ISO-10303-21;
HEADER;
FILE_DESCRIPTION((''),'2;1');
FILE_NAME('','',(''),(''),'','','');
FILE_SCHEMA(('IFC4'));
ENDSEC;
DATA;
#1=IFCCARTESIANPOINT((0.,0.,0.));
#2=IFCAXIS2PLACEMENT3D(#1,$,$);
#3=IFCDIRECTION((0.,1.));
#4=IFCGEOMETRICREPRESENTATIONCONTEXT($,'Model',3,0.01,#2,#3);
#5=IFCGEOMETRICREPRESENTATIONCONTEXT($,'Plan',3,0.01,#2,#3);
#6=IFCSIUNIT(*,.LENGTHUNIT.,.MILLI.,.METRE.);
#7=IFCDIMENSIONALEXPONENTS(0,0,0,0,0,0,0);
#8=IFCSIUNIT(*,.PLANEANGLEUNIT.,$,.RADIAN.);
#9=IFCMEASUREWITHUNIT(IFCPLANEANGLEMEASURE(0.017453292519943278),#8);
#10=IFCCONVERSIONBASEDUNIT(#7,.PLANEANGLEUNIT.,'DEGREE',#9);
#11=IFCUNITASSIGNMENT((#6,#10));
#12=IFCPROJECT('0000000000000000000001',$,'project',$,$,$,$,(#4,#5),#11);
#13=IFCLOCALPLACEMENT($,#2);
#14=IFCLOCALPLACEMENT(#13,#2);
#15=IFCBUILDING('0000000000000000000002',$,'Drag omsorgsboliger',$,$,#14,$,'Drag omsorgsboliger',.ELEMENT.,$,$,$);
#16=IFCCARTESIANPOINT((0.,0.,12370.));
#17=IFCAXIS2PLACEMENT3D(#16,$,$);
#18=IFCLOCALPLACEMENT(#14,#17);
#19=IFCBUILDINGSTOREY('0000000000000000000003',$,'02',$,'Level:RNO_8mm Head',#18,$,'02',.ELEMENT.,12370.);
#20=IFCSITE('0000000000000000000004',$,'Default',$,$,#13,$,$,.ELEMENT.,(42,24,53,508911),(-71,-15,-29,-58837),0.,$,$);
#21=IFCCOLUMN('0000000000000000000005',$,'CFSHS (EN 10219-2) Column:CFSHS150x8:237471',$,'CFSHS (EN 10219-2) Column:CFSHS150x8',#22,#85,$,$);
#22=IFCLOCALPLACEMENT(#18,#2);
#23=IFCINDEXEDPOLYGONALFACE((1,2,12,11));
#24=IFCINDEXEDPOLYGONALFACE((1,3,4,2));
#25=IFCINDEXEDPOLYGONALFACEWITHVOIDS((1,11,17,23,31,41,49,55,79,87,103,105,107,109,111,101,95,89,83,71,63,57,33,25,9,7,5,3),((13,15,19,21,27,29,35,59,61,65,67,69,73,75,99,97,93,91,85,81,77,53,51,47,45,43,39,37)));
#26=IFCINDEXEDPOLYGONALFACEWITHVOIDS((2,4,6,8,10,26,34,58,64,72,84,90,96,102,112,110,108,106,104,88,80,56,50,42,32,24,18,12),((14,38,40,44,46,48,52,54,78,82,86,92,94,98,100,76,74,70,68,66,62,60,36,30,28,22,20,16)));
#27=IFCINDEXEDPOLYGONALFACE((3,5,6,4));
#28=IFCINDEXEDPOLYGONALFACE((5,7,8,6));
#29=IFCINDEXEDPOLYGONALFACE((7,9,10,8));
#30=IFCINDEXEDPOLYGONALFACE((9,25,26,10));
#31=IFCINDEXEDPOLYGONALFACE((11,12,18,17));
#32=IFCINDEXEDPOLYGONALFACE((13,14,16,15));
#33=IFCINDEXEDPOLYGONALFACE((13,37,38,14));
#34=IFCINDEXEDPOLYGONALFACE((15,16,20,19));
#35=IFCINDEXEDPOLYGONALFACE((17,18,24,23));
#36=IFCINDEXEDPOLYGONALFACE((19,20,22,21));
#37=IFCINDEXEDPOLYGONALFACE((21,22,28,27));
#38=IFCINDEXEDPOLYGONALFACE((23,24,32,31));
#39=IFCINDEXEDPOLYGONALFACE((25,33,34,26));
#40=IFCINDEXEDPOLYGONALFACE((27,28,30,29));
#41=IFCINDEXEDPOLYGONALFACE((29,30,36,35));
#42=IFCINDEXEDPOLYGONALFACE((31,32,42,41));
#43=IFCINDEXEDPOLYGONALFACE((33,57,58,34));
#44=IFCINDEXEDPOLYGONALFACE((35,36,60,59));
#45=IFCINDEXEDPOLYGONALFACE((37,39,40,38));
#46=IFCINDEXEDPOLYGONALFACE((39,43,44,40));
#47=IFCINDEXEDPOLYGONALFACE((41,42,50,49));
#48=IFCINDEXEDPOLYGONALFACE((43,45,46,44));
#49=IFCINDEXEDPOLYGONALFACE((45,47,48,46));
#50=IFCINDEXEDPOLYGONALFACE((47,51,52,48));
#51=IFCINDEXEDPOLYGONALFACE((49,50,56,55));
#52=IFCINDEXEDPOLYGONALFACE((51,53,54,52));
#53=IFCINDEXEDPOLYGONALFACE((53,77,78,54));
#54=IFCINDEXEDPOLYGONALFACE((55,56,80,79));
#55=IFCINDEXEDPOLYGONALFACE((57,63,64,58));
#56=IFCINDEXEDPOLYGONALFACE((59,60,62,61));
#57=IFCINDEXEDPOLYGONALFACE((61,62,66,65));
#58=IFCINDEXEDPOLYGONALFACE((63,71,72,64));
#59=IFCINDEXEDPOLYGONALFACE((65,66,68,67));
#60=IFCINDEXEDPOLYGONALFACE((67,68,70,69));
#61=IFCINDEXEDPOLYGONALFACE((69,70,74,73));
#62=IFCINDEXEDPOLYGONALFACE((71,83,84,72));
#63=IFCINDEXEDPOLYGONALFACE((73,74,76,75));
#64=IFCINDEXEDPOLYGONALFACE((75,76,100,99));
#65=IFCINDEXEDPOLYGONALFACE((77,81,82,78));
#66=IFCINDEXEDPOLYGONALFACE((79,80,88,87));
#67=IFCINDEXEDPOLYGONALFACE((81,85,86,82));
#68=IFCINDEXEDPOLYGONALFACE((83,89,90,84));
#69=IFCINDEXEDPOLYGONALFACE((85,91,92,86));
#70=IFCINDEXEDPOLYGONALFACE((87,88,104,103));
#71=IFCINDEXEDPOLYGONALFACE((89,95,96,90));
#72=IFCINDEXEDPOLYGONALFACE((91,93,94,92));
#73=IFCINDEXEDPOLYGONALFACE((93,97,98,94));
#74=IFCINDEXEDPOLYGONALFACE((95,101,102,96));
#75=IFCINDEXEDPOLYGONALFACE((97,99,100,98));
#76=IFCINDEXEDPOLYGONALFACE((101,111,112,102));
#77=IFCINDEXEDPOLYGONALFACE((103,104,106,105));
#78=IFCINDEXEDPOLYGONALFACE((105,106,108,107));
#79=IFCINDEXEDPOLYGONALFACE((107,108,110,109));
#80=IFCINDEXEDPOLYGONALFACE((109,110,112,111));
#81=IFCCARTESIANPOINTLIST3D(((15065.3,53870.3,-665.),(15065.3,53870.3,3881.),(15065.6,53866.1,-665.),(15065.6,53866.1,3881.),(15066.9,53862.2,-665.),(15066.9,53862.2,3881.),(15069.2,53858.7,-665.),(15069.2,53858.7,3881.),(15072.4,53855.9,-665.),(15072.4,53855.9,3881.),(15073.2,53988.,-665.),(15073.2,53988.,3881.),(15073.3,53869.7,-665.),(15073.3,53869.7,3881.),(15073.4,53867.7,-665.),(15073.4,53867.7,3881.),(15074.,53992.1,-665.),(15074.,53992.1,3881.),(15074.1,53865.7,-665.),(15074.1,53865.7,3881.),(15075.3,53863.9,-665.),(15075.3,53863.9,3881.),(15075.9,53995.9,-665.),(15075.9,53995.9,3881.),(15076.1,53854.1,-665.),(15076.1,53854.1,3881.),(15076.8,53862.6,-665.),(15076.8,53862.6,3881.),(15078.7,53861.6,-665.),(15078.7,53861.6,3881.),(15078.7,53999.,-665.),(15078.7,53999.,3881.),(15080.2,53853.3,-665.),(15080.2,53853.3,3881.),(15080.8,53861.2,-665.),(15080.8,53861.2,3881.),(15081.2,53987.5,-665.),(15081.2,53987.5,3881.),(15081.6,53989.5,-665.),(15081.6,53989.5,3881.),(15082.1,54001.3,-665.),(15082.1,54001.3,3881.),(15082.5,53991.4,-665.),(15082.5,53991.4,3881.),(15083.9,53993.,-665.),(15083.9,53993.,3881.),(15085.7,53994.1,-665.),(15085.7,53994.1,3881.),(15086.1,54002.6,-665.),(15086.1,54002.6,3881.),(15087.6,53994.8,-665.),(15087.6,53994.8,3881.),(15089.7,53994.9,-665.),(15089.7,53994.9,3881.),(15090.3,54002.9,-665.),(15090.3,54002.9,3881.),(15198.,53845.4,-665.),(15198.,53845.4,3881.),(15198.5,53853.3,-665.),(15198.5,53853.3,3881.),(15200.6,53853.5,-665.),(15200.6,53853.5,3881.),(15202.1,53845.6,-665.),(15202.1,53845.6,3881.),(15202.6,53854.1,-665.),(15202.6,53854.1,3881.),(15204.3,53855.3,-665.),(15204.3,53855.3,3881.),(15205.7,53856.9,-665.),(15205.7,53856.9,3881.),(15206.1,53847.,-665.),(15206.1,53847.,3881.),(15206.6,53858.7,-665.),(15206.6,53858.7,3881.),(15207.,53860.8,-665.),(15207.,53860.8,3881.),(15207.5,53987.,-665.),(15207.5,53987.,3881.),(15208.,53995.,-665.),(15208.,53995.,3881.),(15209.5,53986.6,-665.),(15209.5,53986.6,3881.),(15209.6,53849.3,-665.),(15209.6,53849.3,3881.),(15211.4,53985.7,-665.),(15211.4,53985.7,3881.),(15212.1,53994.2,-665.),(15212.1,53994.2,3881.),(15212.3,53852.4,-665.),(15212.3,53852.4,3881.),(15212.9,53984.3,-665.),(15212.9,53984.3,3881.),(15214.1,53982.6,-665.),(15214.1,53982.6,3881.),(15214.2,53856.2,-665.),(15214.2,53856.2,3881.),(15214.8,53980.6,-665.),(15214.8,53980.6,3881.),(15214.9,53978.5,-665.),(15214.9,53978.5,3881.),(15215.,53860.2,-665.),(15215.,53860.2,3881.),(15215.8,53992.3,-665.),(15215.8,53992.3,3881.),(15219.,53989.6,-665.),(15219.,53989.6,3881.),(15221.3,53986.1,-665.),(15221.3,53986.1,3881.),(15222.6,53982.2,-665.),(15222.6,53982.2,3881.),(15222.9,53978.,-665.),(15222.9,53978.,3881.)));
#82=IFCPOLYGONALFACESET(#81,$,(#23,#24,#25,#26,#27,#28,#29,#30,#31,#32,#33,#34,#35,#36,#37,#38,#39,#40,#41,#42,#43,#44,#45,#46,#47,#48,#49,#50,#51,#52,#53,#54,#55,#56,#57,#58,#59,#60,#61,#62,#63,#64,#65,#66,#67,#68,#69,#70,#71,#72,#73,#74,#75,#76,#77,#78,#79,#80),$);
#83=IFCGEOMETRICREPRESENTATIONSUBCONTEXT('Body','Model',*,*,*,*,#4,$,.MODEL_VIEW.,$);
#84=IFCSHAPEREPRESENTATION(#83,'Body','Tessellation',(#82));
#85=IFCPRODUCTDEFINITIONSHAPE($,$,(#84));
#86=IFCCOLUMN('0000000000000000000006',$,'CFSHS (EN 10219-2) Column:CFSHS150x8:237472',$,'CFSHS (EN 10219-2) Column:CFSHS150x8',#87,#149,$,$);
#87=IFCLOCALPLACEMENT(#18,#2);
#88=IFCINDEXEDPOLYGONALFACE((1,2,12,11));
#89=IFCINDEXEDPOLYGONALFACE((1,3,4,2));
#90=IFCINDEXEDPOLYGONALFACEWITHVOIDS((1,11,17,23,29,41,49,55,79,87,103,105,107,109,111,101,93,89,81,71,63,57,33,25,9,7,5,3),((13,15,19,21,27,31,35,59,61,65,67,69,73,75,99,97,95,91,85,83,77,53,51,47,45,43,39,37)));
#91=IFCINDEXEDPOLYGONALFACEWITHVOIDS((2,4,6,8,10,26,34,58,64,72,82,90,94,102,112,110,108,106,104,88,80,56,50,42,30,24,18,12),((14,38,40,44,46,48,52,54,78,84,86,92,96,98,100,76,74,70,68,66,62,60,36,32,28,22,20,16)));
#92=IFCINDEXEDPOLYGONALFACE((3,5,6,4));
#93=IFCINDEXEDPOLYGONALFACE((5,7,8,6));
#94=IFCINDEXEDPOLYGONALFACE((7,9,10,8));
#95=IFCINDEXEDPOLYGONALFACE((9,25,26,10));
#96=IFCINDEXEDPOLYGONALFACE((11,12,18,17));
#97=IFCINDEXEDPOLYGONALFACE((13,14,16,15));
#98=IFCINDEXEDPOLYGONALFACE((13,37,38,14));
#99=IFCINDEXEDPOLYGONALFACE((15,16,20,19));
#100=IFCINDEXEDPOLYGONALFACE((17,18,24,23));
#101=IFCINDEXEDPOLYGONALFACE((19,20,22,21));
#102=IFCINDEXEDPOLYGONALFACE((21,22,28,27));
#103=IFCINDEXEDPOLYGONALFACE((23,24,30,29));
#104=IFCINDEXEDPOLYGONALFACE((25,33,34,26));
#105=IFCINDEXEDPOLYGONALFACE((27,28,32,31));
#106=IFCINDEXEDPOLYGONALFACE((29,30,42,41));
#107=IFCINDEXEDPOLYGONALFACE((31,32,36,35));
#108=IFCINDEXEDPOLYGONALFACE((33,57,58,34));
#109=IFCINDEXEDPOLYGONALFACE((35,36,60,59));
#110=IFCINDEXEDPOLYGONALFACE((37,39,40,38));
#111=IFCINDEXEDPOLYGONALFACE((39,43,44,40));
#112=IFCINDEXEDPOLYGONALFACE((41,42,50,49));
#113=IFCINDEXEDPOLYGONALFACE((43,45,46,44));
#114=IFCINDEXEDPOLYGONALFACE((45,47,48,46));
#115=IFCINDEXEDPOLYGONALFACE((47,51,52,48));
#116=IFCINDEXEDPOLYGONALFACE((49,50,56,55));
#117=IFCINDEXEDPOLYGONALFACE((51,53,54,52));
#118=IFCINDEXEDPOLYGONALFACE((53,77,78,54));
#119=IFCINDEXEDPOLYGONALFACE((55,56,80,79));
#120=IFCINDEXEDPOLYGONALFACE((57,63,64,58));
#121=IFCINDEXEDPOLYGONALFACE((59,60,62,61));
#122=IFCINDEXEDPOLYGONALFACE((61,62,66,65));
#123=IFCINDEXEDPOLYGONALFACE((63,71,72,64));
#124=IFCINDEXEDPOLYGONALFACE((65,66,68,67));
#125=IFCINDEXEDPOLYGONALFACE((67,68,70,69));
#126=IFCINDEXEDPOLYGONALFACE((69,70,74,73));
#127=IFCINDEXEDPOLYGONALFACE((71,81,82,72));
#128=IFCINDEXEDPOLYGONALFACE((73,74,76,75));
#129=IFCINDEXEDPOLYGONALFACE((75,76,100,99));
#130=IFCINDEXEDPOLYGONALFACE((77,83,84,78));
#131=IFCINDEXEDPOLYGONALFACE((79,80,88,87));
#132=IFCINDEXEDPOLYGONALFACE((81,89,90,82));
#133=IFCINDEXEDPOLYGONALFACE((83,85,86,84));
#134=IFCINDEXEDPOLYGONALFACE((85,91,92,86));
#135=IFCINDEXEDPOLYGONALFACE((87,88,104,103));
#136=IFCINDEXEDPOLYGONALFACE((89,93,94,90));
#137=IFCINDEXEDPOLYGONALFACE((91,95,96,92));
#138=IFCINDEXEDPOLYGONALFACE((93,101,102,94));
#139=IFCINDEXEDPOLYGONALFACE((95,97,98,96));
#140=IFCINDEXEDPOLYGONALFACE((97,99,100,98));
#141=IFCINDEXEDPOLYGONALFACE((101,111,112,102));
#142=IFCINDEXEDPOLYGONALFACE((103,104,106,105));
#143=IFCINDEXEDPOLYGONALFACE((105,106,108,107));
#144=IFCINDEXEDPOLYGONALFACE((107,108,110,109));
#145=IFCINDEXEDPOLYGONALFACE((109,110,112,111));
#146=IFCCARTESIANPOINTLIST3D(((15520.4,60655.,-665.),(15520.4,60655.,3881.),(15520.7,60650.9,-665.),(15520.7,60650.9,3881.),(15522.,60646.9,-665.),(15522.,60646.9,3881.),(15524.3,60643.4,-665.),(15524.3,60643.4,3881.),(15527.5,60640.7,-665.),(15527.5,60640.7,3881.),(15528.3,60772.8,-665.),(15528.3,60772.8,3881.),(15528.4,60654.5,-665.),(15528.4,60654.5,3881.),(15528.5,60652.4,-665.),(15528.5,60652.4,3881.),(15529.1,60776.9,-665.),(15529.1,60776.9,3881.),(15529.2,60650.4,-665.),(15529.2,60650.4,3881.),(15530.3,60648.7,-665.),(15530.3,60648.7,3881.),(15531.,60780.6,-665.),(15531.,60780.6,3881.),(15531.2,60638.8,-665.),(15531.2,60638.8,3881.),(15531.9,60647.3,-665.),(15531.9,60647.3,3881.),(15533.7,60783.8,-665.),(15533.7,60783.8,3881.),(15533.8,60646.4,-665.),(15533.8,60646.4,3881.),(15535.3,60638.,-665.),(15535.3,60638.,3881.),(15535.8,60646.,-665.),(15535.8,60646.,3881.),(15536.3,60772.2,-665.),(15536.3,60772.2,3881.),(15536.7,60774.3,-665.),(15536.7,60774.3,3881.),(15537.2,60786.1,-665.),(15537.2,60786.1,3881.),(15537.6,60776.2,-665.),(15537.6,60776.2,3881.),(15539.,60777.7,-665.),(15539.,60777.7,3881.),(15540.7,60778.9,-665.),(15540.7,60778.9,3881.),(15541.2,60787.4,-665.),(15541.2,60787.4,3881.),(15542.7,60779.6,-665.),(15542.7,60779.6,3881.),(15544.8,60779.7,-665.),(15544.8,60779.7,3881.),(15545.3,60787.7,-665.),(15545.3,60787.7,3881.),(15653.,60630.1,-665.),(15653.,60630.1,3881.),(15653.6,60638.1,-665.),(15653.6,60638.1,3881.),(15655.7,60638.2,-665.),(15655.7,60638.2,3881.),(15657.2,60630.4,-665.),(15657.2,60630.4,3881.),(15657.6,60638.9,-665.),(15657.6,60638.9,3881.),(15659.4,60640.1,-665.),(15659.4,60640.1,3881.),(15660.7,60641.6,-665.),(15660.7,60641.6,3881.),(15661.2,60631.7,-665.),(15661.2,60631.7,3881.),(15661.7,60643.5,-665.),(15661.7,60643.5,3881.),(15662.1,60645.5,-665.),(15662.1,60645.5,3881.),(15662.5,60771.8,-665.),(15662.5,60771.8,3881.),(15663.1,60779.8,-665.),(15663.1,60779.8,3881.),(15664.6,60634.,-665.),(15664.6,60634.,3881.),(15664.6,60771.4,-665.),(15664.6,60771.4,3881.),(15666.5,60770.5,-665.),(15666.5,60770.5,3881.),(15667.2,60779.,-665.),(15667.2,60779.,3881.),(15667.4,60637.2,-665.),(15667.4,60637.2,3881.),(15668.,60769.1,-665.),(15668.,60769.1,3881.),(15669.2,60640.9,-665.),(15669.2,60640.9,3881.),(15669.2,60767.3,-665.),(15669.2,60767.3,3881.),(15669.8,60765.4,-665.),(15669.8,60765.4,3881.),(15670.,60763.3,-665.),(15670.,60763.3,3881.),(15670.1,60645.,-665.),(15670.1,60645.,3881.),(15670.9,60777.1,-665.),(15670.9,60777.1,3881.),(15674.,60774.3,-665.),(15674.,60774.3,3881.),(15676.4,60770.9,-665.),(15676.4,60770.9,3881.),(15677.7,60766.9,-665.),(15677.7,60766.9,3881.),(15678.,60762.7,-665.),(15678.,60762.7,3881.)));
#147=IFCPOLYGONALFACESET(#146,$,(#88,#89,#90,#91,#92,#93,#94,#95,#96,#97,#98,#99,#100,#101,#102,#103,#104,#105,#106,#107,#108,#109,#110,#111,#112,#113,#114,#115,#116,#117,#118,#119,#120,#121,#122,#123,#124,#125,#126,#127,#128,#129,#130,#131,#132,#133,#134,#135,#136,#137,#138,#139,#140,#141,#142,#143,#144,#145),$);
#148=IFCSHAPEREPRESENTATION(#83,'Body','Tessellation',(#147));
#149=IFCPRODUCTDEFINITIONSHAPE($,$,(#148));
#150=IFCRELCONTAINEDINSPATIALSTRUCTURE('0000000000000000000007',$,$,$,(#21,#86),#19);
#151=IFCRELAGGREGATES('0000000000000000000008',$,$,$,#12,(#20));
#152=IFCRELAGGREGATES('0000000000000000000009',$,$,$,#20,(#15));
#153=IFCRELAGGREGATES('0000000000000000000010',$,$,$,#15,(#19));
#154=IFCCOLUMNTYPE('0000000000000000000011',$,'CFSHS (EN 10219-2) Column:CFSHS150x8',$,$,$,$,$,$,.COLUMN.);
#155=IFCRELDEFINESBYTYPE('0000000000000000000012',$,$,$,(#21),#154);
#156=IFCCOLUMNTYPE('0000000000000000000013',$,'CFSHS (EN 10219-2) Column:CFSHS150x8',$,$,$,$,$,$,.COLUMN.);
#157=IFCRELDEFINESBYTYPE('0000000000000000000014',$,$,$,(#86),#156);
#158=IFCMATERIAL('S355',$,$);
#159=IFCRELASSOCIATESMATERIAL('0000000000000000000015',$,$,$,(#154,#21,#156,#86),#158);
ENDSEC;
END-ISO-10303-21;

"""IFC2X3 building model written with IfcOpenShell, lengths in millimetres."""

from ifc_helpers import new_model, entity, si_unit, converted_unit, direction, frame, frame_2d, origin, place, context, subcontext, project, spatial, polyline, circle_curve, parameter, trimmed, segment, composite_curve, outline, extrude, source, transform, mapped, material, type_object, type_shapes, element, save


model = new_model("IFC2X3")

# Units and contexts
model_context = context("Model", 3, precision=0.01, world=origin(), true_north=direction((0.0, 1.0)))
plan_context = context("Plan", 3, precision=0.01, world=origin(), true_north=direction((0.0, 1.0)))
body_context = subcontext(model_context, "Body", "Model", "MODEL_VIEW")
ifc_project = project(units=[si_unit("LENGTHUNIT", "METRE", prefix="MILLI"), converted_unit("PLANEANGLEUNIT", "DEGREE", entity("IfcPlaneAngleMeasure", 0.017453292519943278), si_unit("PLANEANGLEUNIT", "RADIAN"), dimensions=[0, 0, 0, 0, 0, 0, 0])], contexts=[model_context, plan_context])

# Site, building, storey
site_placement = place(None, origin())
site = spatial("IfcSite", under=ifc_project, at=site_placement, Name="Default", CompositionType="ELEMENT", RefLatitude=(42, 24, 53, 508911), RefLongitude=(-71, -15, -29, -58837), RefElevation=0.0)
building_placement = place(site_placement, origin())
building = spatial("IfcBuilding", under=site, at=building_placement, Name="Drag omsorgsboliger", LongName="Drag omsorgsboliger", CompositionType="ELEMENT")
storey_placement = place(building_placement, frame((0.0, 0.0, 12370.0)))
storey = spatial("IfcBuildingStorey", under=building, at=storey_placement, Name="02", ObjectType="Level:RNO_8mm Head", LongName="02", CompositionType="ELEMENT", Elevation=12370.0)

# Columns
ifc_material = material(Name="S355")
column_type_1 = type_object("IfcColumnType", Name="CFSHS (EN 10219-2) Column:CFSHS150x8", PredefinedType="COLUMN", material=ifc_material)
shared_shape_1 = source(origin(), body_context, "Body", "SweptSolid", [
    extrude(outline(composite_curve([segment(polyline([(-59.0, -75.0), (59.0, -75.0)]), True, "CONTINUOUS"), segment(trimmed(circle_curve(frame_2d((59.0, -59.0), x_axis=(-1.0, 0.0)), 16.0), [parameter(90.0)], [parameter(180.0)], True, "PARAMETER"), True, "CONTINUOUS"), segment(polyline([(75.0, -59.0), (75.0, 59.0)]), True, "CONTINUOUS"), segment(trimmed(circle_curve(frame_2d((59.0, 59.0), x_axis=(-1.0, 0.0)), 16.0), [parameter(180.0)], [parameter(270.0)], True, "PARAMETER"), True, "CONTINUOUS"), segment(polyline([(59.0, 75.0), (-59.0, 75.0)]), True, "CONTINUOUS"), segment(trimmed(circle_curve(frame_2d((-59.0, 59.0), x_axis=(-1.0, 0.0)), 16.0), [parameter(270.0)], [parameter(360.0)], True, "PARAMETER"), True, "CONTINUOUS"), segment(polyline([(-75.0, 59.0), (-75.0, -59.0)]), True, "CONTINUOUS"), segment(trimmed(circle_curve(frame_2d((-59.0, -59.0), x_axis=(-1.0, 0.0)), 16.0), [parameter(360.0)], [parameter(90.0)], True, "PARAMETER"), True, "CONTINUOUS")], self_intersect=False), holes=[composite_curve([segment(trimmed(circle_curve(frame_2d((-59.0, -59.0), x_axis=(-1.0, 0.0)), 8.0), [parameter(360.0)], [parameter(90.0)], True, "PARAMETER"), False, "CONTINUOUS"), segment(polyline([(-67.0, -59.0), (-67.0, 59.0)]), True, "CONTINUOUS"), segment(trimmed(circle_curve(frame_2d((-59.0, 59.0), x_axis=(-1.0, 0.0)), 8.0), [parameter(270.0)], [parameter(360.0)], True, "PARAMETER"), False, "CONTINUOUS"), segment(polyline([(-59.0, 67.0), (59.0, 67.0)]), True, "CONTINUOUS"), segment(trimmed(circle_curve(frame_2d((59.0, 59.0), x_axis=(-1.0, 0.0)), 8.0), [parameter(180.0)], [parameter(270.0)], True, "PARAMETER"), False, "CONTINUOUS"), segment(polyline([(67.0, 59.0), (67.0, -59.0)]), True, "CONTINUOUS"), segment(trimmed(circle_curve(frame_2d((59.0, -59.0), x_axis=(-1.0, 0.0)), 8.0), [parameter(90.0)], [parameter(180.0)], True, "PARAMETER"), False, "CONTINUOUS"), segment(polyline([(59.0, -67.0), (-59.0, -67.0)]), True, "CONTINUOUS")], self_intersect=False)]), frame((15144.1, 53924.1, 11705.0), z_axis=(0.0, 0.0, 1.0), x_axis=(-0.997758, 0.066923, 0.0)), (0.0, 0.0, 1.0), 4546.0),
])
type_shapes(column_type_1, [shared_shape_1])
column_1_placement = place(storey_placement, frame((0.0, 0.0, -12370.0)))
element("IfcColumn", 1, at=column_1_placement, inside=storey, type_object=column_type_1, material=ifc_material, Name="CFSHS (EN 10219-2) Column:CFSHS150x8:237471", ObjectType="CFSHS (EN 10219-2) Column:CFSHS150x8", context=body_context, shape_type="MappedRepresentation", body=[
    mapped(shared_shape_1, transform((0.0, 0.0, 0.0), scale=1.0)),
])
column_type_2 = type_object("IfcColumnType", Name="CFSHS (EN 10219-2) Column:CFSHS150x8", PredefinedType="COLUMN", material=ifc_material)
shared_shape_2 = source(origin(), body_context, "Body", "SweptSolid", [
    extrude(outline(composite_curve([segment(polyline([(-59.0, -75.0), (59.0, -75.0)]), True, "CONTINUOUS"), segment(trimmed(circle_curve(frame_2d((59.0, -59.0), x_axis=(-1.0, 0.0)), 16.0), [parameter(90.0)], [parameter(180.0)], True, "PARAMETER"), True, "CONTINUOUS"), segment(polyline([(75.0, -59.0), (75.0, 59.0)]), True, "CONTINUOUS"), segment(trimmed(circle_curve(frame_2d((59.0, 59.0), x_axis=(-1.0, 0.0)), 16.0), [parameter(180.0)], [parameter(270.0)], True, "PARAMETER"), True, "CONTINUOUS"), segment(polyline([(59.0, 75.0), (-59.0, 75.0)]), True, "CONTINUOUS"), segment(trimmed(circle_curve(frame_2d((-59.0, 59.0), x_axis=(-1.0, 0.0)), 16.0), [parameter(270.0)], [parameter(360.0)], True, "PARAMETER"), True, "CONTINUOUS"), segment(polyline([(-75.0, 59.0), (-75.0, -59.0)]), True, "CONTINUOUS"), segment(trimmed(circle_curve(frame_2d((-59.0, -59.0), x_axis=(-1.0, 0.0)), 16.0), [parameter(360.0)], [parameter(90.0)], True, "PARAMETER"), True, "CONTINUOUS")], self_intersect=False), holes=[composite_curve([segment(trimmed(circle_curve(frame_2d((-59.0, -59.0), x_axis=(-1.0, 0.0)), 8.0), [parameter(360.0)], [parameter(90.0)], True, "PARAMETER"), False, "CONTINUOUS"), segment(polyline([(-67.0, -59.0), (-67.0, 59.0)]), True, "CONTINUOUS"), segment(trimmed(circle_curve(frame_2d((-59.0, 59.0), x_axis=(-1.0, 0.0)), 8.0), [parameter(270.0)], [parameter(360.0)], True, "PARAMETER"), False, "CONTINUOUS"), segment(polyline([(-59.0, 67.0), (59.0, 67.0)]), True, "CONTINUOUS"), segment(trimmed(circle_curve(frame_2d((59.0, 59.0), x_axis=(-1.0, 0.0)), 8.0), [parameter(180.0)], [parameter(270.0)], True, "PARAMETER"), False, "CONTINUOUS"), segment(polyline([(67.0, 59.0), (67.0, -59.0)]), True, "CONTINUOUS"), segment(trimmed(circle_curve(frame_2d((59.0, -59.0), x_axis=(-1.0, 0.0)), 8.0), [parameter(90.0)], [parameter(180.0)], True, "PARAMETER"), False, "CONTINUOUS"), segment(polyline([(59.0, -67.0), (-59.0, -67.0)]), True, "CONTINUOUS")], self_intersect=False)]), frame((15599.2, 60708.9, 11705.0), z_axis=(0.0, 0.0, 1.0), x_axis=(-0.997758, 0.066923, 0.0)), (0.0, 0.0, 1.0), 4546.0),
])
type_shapes(column_type_2, [shared_shape_2])
column_2_placement = place(storey_placement, frame((0.0, 0.0, -12370.0)))
element("IfcColumn", 2, at=column_2_placement, inside=storey, type_object=column_type_2, material=ifc_material, Name="CFSHS (EN 10219-2) Column:CFSHS150x8:237472", ObjectType="CFSHS (EN 10219-2) Column:CFSHS150x8", context=body_context, shape_type="MappedRepresentation", body=[
    mapped(shared_shape_2, transform((0.0, 0.0, 0.0), scale=1.0)),
])

save(model, "model.ifc")
